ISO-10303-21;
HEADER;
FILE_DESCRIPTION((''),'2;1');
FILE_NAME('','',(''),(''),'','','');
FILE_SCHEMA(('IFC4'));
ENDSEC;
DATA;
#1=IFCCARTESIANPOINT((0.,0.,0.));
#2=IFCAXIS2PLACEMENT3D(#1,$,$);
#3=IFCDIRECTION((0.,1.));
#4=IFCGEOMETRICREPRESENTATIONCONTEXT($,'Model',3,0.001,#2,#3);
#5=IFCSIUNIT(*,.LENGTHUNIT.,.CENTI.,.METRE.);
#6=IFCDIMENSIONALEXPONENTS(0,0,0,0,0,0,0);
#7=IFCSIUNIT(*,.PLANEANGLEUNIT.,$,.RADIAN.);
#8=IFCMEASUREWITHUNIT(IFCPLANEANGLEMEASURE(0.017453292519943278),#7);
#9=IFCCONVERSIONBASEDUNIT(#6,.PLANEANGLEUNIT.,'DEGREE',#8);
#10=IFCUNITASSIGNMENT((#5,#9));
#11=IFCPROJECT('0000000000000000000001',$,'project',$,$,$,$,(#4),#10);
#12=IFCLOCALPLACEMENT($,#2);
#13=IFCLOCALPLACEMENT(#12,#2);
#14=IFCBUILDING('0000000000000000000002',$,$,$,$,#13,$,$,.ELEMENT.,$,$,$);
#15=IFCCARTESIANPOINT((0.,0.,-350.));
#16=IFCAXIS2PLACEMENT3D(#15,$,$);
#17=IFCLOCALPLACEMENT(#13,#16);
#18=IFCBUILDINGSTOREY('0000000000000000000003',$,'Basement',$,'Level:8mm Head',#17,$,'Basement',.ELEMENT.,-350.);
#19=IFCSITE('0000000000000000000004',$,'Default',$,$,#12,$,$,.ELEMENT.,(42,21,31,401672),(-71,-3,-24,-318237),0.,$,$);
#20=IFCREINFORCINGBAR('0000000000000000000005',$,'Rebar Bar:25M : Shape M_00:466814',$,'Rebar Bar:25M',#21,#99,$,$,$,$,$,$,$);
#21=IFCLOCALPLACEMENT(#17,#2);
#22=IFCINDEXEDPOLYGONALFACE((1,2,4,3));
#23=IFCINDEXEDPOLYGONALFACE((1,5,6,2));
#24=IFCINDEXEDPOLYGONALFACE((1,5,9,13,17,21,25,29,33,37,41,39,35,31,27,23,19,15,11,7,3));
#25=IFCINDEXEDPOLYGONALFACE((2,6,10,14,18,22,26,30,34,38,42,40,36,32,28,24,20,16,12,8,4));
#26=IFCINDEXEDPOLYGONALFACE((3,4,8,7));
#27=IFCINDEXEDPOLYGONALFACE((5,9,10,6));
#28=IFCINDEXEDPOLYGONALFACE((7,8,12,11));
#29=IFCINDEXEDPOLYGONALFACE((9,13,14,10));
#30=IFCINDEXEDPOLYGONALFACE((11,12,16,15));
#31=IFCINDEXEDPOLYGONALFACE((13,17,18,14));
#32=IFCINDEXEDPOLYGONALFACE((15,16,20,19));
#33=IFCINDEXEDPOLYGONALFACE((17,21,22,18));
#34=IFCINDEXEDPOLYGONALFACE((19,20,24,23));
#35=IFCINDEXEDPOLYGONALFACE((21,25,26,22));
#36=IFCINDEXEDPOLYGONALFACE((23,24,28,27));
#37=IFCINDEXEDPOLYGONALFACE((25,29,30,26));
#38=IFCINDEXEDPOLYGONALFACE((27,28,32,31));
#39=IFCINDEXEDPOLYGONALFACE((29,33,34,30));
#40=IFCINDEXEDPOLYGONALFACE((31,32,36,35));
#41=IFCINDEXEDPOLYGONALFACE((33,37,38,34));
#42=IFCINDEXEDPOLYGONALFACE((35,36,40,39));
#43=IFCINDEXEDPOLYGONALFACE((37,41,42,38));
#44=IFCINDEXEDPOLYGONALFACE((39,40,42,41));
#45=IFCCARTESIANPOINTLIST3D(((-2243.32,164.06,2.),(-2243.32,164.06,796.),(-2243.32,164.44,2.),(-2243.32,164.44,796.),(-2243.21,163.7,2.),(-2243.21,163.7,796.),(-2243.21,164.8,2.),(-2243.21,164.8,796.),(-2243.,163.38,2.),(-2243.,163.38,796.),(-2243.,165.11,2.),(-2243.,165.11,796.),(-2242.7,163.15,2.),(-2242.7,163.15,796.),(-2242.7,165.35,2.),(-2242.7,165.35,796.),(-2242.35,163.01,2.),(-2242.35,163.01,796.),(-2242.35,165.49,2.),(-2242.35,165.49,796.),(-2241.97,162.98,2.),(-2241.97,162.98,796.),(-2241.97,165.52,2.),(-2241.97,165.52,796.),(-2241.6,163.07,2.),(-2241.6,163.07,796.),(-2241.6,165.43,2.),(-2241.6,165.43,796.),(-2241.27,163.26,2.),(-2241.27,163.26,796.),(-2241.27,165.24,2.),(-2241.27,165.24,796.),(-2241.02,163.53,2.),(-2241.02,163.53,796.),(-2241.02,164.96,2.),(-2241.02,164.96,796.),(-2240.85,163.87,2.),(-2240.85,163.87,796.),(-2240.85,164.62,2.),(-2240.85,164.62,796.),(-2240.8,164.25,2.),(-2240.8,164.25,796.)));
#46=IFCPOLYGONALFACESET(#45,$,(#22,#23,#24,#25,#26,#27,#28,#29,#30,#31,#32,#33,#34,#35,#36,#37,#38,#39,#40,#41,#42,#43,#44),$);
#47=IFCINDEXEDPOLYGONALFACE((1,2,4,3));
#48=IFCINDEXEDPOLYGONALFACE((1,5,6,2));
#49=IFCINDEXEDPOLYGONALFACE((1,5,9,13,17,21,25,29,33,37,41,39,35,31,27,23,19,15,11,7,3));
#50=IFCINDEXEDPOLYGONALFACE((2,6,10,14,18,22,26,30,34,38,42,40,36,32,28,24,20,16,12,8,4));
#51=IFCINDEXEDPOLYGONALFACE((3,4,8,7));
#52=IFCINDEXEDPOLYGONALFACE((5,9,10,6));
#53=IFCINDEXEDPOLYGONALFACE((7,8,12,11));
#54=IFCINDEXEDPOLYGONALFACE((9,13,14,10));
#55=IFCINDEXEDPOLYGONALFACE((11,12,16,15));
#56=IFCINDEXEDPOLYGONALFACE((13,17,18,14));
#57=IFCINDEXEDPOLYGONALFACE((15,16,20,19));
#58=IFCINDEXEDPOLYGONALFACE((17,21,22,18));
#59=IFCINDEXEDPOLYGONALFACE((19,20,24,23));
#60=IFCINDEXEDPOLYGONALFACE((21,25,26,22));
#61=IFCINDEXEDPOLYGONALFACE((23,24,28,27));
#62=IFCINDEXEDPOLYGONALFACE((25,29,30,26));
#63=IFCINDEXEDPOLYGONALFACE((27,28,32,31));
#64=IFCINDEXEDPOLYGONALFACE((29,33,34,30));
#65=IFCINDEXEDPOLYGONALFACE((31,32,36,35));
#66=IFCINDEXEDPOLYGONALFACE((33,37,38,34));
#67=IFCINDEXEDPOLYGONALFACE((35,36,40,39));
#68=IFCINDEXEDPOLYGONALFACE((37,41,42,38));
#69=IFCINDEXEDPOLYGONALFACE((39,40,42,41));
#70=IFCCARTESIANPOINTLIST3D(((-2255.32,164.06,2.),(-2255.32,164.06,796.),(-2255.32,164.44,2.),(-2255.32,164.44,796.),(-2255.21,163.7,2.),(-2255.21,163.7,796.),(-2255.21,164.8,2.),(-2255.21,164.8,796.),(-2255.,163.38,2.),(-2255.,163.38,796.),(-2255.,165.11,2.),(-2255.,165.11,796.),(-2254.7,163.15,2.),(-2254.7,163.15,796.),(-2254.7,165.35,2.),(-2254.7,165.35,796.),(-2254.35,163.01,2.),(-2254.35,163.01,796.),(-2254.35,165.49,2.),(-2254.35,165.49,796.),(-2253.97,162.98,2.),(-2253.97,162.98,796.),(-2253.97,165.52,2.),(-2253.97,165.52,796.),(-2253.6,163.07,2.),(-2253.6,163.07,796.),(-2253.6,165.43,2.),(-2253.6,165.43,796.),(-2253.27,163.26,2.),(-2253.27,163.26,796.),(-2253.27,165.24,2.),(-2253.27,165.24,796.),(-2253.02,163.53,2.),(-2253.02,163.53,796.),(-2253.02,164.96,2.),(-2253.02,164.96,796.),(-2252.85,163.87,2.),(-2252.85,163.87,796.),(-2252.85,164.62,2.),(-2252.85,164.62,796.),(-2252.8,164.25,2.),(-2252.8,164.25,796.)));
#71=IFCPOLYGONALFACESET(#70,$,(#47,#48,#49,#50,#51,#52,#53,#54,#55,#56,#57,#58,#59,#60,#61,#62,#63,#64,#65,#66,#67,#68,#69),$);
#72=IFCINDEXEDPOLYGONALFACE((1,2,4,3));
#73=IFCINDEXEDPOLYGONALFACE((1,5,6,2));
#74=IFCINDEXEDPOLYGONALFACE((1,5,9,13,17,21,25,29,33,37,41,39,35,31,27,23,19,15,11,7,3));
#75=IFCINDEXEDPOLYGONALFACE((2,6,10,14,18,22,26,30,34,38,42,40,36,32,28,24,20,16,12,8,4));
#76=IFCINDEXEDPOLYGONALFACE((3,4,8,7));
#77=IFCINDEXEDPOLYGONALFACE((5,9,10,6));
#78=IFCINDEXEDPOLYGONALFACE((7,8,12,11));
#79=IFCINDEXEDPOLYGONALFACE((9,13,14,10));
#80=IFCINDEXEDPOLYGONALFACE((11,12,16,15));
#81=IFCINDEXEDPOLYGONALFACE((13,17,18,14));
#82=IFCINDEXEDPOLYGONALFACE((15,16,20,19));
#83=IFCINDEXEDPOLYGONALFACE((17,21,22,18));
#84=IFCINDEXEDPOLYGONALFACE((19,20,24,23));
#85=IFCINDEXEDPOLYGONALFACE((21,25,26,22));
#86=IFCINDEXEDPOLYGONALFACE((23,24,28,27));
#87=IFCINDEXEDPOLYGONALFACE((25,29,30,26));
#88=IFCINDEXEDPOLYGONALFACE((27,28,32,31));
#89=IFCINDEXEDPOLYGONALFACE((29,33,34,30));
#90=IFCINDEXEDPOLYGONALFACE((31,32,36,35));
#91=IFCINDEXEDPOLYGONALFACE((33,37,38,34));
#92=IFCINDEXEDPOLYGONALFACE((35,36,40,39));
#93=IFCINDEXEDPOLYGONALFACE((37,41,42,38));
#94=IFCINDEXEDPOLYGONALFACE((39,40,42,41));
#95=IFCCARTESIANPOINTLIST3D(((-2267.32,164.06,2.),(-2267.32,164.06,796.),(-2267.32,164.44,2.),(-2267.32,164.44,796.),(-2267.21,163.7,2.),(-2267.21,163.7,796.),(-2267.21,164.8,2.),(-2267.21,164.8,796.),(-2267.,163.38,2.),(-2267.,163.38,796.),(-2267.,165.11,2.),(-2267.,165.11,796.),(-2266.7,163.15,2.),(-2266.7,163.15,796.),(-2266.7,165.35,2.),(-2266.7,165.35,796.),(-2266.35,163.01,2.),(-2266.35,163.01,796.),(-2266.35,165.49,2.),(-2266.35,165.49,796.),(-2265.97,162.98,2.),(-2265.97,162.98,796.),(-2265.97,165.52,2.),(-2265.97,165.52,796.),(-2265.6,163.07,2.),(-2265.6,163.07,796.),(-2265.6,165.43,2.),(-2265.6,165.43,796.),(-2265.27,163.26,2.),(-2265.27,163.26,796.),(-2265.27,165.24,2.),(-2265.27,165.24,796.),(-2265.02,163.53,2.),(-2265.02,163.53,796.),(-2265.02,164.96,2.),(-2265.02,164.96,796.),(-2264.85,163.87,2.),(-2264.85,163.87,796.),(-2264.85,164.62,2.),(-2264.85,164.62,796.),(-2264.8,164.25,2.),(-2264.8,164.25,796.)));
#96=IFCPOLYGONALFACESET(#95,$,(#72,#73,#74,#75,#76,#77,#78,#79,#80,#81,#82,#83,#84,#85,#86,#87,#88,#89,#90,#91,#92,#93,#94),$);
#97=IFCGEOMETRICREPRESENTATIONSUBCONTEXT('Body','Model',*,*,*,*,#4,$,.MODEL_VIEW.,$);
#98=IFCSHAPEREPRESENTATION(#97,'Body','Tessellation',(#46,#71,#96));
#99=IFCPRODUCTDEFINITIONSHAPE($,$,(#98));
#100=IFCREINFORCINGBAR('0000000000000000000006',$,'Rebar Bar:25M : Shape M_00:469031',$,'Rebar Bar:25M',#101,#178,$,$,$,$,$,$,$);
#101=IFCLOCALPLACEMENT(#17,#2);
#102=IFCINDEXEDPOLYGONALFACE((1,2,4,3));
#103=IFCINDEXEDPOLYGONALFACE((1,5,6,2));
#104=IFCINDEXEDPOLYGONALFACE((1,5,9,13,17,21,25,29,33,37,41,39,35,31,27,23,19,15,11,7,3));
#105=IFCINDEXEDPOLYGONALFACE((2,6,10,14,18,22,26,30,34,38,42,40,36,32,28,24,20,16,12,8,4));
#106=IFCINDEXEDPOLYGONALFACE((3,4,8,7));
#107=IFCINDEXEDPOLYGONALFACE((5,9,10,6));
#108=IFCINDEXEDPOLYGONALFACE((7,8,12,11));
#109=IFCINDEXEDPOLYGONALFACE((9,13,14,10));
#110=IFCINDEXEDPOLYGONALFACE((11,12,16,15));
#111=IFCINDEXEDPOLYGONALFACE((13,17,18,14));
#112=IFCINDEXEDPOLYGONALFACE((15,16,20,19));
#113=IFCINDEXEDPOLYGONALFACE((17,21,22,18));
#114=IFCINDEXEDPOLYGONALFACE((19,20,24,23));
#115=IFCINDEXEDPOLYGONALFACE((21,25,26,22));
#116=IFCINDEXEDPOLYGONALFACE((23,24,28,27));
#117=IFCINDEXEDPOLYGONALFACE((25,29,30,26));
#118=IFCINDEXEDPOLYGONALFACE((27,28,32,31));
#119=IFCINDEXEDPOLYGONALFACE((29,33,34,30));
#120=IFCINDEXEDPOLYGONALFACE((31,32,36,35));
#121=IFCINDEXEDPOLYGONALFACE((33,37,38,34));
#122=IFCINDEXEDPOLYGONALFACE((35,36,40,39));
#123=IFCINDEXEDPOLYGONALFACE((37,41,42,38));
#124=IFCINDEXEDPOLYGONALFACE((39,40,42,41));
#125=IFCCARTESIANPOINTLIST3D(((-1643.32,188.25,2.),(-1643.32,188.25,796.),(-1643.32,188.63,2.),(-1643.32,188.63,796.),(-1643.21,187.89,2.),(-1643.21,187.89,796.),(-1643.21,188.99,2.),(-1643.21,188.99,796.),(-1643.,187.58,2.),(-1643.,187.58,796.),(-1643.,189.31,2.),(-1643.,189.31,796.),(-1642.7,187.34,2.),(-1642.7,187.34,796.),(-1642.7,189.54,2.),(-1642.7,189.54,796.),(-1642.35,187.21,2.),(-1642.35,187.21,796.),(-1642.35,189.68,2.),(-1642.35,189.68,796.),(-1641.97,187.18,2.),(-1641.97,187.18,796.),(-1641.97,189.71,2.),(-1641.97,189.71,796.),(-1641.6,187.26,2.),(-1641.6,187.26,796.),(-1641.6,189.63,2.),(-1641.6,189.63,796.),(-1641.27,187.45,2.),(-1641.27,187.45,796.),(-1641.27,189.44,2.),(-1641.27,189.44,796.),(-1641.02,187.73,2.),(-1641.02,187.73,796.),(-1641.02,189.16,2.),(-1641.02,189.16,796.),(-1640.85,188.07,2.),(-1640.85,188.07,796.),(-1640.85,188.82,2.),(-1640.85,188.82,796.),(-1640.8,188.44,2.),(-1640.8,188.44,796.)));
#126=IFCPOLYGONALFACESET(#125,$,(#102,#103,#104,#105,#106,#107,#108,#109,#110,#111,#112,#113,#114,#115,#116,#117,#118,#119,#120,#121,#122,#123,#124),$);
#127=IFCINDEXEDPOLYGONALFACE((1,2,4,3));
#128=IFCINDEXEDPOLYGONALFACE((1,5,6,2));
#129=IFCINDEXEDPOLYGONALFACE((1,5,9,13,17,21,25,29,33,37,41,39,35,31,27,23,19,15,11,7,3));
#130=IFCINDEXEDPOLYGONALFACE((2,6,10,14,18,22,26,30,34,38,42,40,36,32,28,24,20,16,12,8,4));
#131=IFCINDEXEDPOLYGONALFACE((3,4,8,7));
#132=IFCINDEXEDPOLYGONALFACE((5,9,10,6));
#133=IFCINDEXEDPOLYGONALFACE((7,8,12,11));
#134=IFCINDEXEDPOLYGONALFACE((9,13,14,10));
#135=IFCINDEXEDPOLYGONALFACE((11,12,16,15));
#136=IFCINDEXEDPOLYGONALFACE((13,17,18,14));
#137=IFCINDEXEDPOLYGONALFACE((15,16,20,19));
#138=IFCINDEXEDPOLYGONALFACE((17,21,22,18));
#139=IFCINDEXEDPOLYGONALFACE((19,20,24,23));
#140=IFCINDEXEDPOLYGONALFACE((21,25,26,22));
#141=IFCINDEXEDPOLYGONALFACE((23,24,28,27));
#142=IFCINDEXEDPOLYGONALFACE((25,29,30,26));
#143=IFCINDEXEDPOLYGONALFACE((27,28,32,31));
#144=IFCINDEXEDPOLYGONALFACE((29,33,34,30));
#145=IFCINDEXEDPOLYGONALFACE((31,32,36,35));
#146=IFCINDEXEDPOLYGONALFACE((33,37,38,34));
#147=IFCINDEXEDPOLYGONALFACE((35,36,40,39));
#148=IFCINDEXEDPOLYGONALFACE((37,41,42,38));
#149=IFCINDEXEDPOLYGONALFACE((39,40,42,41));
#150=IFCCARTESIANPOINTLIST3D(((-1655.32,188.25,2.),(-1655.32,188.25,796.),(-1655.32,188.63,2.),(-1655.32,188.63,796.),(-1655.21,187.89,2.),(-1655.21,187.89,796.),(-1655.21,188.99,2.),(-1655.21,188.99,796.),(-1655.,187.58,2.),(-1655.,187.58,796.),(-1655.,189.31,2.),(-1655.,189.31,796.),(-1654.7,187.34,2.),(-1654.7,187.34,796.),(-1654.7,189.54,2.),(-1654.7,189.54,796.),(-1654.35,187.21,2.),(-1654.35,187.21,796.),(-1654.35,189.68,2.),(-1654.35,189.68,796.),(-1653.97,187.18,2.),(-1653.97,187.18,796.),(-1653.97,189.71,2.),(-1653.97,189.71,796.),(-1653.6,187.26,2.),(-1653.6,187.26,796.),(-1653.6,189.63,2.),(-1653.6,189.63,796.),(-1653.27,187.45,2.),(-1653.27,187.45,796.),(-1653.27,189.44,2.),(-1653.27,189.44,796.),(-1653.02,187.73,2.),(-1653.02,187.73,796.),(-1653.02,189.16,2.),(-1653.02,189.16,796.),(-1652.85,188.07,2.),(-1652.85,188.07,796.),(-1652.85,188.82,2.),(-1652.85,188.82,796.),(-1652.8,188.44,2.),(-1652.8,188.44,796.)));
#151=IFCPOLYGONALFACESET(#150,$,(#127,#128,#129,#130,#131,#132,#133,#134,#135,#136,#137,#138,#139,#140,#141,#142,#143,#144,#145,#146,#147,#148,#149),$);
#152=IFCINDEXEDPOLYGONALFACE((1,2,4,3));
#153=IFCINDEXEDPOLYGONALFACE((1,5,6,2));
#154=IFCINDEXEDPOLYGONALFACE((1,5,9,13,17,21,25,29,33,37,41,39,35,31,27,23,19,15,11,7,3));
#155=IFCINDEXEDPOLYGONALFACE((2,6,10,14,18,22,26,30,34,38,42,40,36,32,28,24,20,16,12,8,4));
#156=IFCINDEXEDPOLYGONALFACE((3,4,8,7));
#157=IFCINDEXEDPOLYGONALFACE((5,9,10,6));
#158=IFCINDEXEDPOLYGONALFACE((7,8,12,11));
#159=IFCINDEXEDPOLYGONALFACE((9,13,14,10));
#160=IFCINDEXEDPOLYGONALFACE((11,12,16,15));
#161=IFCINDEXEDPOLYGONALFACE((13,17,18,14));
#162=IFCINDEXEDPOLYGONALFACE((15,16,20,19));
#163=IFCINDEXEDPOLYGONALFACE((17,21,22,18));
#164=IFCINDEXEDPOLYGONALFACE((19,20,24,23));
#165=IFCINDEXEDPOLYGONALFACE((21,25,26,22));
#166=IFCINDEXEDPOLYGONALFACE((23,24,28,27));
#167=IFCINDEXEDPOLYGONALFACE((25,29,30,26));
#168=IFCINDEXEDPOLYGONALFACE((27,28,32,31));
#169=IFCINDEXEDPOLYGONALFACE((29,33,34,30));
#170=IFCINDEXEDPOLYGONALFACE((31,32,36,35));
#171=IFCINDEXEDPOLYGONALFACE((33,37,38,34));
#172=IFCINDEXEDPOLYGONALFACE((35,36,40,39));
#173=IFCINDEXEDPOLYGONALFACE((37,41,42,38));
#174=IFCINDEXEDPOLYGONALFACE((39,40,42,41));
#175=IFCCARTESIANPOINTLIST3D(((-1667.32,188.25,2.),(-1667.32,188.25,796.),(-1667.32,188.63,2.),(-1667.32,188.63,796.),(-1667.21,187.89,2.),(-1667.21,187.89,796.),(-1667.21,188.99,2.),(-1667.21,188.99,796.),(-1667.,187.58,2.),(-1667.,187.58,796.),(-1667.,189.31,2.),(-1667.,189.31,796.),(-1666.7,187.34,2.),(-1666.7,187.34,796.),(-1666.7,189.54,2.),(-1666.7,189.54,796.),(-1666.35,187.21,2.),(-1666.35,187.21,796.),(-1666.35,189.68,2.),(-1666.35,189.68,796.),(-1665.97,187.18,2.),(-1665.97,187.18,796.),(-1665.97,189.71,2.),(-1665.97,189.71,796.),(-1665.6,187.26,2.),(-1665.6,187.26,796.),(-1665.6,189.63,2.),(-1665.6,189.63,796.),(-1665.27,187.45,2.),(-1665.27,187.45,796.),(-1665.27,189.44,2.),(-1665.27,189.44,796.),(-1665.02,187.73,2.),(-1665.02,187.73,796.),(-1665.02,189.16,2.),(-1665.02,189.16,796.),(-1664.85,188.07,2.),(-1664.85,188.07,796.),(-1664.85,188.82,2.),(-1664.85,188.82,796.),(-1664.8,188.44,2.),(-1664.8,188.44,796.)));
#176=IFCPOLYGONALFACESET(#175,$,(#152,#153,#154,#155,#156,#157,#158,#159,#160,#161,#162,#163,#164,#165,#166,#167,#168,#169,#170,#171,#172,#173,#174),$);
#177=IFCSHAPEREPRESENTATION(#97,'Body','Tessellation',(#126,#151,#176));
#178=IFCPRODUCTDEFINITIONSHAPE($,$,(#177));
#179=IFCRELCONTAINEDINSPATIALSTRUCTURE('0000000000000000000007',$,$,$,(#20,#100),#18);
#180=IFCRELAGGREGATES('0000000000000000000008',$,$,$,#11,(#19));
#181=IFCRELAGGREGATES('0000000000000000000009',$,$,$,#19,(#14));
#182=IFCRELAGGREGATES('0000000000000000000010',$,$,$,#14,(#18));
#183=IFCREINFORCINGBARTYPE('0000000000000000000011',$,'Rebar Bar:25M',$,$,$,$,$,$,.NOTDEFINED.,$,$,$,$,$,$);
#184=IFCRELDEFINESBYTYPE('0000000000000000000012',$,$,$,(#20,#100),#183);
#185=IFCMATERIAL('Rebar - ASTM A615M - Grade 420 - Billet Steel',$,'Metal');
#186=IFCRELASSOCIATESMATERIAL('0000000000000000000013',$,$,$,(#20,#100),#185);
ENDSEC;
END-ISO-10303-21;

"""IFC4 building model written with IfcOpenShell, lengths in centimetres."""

from ifc_helpers import new_model, entity, si_unit, converted_unit, direction, frame, origin, place, context, subcontext, project, spatial, material, type_object, element, save


model = new_model("IFC4")

# Units and contexts
model_context = context("Model", 3, precision=0.001, world=origin(), true_north=direction((0.0, 1.0)))
body_context = subcontext(model_context, "Body", "Model", "MODEL_VIEW")
ifc_project = project(units=[si_unit("LENGTHUNIT", "METRE", prefix="CENTI"), converted_unit("PLANEANGLEUNIT", "DEGREE", entity("IfcPlaneAngleMeasure", 0.017453292519943278), si_unit("PLANEANGLEUNIT", "RADIAN"), dimensions=[0, 0, 0, 0, 0, 0, 0])], contexts=[model_context])

# Site, building, storey
site_placement = place(None, origin())
site = spatial("IfcSite", under=ifc_project, at=site_placement, Name="Default", CompositionType="ELEMENT", RefLatitude=(42, 21, 31, 401672), RefLongitude=(-71, -3, -24, -318237), RefElevation=0.0)
building_placement = place(site_placement, origin())
building = spatial("IfcBuilding", under=site, at=building_placement, CompositionType="ELEMENT")
storey_placement = place(building_placement, frame((0.0, 0.0, -350.0)))
storey = spatial("IfcBuildingStorey", under=building, at=storey_placement, Name="Basement", ObjectType="Level:8mm Head", LongName="Basement", CompositionType="ELEMENT", Elevation=-350.0)

# Reinforcing bars
ifc_material_1 = material(Name="Rebar - ASTM A615M - Grade 420 - Billet Steel", Category="Metal")
reinforcing_bar_type_1 = type_object("IfcReinforcingBarType", Name="Rebar Bar:25M", PredefinedType="NOTDEFINED")
reinforcing_bar_1_placement = place(storey_placement, origin())
element("IfcReinforcingBar", 1, at=reinforcing_bar_1_placement, inside=storey, type_object=reinforcing_bar_type_1, material=ifc_material_1, Name="Rebar Bar:25M : Shape M_00:466814", ObjectType="Rebar Bar:25M", context=body_context, shape_type="AdvancedSweptSolid", body=[
    entity("IfcSweptDiskSolid", entity("IfcIndexedPolyCurve", entity("IfcCartesianPointList3D", [[-2242.07, 164.25, 2.0], [-2242.07, 164.25, 796.0]]), None, False), 1.27, None, 0.0, 1.0),
    entity("IfcSweptDiskSolid", entity("IfcIndexedPolyCurve", entity("IfcCartesianPointList3D", [[-2254.07, 164.25, 2.0], [-2254.07, 164.25, 796.0]]), None, False), 1.27, None, 0.0, 1.0),
    entity("IfcSweptDiskSolid", entity("IfcIndexedPolyCurve", entity("IfcCartesianPointList3D", [[-2266.07, 164.25, 2.0], [-2266.07, 164.25, 796.0]]), None, False), 1.27, None, 0.0, 1.0),
])
reinforcing_bar_2_placement = place(storey_placement, origin())
element("IfcReinforcingBar", 2, at=reinforcing_bar_2_placement, inside=storey, type_object=reinforcing_bar_type_1, material=ifc_material_1, Name="Rebar Bar:25M : Shape M_00:469031", ObjectType="Rebar Bar:25M", context=body_context, shape_type="AdvancedSweptSolid", body=[
    entity("IfcSweptDiskSolid", entity("IfcIndexedPolyCurve", entity("IfcCartesianPointList3D", [[-1642.07, 188.44, 2.0], [-1642.07, 188.44, 796.0]]), None, False), 1.27, None, 0.0, 1.0),
    entity("IfcSweptDiskSolid", entity("IfcIndexedPolyCurve", entity("IfcCartesianPointList3D", [[-1654.07, 188.44, 2.0], [-1654.07, 188.44, 796.0]]), None, False), 1.27, None, 0.0, 1.0),
    entity("IfcSweptDiskSolid", entity("IfcIndexedPolyCurve", entity("IfcCartesianPointList3D", [[-1666.07, 188.44, 2.0], [-1666.07, 188.44, 796.0]]), None, False), 1.27, None, 0.0, 1.0),
])

save(model, "model.ifc")
